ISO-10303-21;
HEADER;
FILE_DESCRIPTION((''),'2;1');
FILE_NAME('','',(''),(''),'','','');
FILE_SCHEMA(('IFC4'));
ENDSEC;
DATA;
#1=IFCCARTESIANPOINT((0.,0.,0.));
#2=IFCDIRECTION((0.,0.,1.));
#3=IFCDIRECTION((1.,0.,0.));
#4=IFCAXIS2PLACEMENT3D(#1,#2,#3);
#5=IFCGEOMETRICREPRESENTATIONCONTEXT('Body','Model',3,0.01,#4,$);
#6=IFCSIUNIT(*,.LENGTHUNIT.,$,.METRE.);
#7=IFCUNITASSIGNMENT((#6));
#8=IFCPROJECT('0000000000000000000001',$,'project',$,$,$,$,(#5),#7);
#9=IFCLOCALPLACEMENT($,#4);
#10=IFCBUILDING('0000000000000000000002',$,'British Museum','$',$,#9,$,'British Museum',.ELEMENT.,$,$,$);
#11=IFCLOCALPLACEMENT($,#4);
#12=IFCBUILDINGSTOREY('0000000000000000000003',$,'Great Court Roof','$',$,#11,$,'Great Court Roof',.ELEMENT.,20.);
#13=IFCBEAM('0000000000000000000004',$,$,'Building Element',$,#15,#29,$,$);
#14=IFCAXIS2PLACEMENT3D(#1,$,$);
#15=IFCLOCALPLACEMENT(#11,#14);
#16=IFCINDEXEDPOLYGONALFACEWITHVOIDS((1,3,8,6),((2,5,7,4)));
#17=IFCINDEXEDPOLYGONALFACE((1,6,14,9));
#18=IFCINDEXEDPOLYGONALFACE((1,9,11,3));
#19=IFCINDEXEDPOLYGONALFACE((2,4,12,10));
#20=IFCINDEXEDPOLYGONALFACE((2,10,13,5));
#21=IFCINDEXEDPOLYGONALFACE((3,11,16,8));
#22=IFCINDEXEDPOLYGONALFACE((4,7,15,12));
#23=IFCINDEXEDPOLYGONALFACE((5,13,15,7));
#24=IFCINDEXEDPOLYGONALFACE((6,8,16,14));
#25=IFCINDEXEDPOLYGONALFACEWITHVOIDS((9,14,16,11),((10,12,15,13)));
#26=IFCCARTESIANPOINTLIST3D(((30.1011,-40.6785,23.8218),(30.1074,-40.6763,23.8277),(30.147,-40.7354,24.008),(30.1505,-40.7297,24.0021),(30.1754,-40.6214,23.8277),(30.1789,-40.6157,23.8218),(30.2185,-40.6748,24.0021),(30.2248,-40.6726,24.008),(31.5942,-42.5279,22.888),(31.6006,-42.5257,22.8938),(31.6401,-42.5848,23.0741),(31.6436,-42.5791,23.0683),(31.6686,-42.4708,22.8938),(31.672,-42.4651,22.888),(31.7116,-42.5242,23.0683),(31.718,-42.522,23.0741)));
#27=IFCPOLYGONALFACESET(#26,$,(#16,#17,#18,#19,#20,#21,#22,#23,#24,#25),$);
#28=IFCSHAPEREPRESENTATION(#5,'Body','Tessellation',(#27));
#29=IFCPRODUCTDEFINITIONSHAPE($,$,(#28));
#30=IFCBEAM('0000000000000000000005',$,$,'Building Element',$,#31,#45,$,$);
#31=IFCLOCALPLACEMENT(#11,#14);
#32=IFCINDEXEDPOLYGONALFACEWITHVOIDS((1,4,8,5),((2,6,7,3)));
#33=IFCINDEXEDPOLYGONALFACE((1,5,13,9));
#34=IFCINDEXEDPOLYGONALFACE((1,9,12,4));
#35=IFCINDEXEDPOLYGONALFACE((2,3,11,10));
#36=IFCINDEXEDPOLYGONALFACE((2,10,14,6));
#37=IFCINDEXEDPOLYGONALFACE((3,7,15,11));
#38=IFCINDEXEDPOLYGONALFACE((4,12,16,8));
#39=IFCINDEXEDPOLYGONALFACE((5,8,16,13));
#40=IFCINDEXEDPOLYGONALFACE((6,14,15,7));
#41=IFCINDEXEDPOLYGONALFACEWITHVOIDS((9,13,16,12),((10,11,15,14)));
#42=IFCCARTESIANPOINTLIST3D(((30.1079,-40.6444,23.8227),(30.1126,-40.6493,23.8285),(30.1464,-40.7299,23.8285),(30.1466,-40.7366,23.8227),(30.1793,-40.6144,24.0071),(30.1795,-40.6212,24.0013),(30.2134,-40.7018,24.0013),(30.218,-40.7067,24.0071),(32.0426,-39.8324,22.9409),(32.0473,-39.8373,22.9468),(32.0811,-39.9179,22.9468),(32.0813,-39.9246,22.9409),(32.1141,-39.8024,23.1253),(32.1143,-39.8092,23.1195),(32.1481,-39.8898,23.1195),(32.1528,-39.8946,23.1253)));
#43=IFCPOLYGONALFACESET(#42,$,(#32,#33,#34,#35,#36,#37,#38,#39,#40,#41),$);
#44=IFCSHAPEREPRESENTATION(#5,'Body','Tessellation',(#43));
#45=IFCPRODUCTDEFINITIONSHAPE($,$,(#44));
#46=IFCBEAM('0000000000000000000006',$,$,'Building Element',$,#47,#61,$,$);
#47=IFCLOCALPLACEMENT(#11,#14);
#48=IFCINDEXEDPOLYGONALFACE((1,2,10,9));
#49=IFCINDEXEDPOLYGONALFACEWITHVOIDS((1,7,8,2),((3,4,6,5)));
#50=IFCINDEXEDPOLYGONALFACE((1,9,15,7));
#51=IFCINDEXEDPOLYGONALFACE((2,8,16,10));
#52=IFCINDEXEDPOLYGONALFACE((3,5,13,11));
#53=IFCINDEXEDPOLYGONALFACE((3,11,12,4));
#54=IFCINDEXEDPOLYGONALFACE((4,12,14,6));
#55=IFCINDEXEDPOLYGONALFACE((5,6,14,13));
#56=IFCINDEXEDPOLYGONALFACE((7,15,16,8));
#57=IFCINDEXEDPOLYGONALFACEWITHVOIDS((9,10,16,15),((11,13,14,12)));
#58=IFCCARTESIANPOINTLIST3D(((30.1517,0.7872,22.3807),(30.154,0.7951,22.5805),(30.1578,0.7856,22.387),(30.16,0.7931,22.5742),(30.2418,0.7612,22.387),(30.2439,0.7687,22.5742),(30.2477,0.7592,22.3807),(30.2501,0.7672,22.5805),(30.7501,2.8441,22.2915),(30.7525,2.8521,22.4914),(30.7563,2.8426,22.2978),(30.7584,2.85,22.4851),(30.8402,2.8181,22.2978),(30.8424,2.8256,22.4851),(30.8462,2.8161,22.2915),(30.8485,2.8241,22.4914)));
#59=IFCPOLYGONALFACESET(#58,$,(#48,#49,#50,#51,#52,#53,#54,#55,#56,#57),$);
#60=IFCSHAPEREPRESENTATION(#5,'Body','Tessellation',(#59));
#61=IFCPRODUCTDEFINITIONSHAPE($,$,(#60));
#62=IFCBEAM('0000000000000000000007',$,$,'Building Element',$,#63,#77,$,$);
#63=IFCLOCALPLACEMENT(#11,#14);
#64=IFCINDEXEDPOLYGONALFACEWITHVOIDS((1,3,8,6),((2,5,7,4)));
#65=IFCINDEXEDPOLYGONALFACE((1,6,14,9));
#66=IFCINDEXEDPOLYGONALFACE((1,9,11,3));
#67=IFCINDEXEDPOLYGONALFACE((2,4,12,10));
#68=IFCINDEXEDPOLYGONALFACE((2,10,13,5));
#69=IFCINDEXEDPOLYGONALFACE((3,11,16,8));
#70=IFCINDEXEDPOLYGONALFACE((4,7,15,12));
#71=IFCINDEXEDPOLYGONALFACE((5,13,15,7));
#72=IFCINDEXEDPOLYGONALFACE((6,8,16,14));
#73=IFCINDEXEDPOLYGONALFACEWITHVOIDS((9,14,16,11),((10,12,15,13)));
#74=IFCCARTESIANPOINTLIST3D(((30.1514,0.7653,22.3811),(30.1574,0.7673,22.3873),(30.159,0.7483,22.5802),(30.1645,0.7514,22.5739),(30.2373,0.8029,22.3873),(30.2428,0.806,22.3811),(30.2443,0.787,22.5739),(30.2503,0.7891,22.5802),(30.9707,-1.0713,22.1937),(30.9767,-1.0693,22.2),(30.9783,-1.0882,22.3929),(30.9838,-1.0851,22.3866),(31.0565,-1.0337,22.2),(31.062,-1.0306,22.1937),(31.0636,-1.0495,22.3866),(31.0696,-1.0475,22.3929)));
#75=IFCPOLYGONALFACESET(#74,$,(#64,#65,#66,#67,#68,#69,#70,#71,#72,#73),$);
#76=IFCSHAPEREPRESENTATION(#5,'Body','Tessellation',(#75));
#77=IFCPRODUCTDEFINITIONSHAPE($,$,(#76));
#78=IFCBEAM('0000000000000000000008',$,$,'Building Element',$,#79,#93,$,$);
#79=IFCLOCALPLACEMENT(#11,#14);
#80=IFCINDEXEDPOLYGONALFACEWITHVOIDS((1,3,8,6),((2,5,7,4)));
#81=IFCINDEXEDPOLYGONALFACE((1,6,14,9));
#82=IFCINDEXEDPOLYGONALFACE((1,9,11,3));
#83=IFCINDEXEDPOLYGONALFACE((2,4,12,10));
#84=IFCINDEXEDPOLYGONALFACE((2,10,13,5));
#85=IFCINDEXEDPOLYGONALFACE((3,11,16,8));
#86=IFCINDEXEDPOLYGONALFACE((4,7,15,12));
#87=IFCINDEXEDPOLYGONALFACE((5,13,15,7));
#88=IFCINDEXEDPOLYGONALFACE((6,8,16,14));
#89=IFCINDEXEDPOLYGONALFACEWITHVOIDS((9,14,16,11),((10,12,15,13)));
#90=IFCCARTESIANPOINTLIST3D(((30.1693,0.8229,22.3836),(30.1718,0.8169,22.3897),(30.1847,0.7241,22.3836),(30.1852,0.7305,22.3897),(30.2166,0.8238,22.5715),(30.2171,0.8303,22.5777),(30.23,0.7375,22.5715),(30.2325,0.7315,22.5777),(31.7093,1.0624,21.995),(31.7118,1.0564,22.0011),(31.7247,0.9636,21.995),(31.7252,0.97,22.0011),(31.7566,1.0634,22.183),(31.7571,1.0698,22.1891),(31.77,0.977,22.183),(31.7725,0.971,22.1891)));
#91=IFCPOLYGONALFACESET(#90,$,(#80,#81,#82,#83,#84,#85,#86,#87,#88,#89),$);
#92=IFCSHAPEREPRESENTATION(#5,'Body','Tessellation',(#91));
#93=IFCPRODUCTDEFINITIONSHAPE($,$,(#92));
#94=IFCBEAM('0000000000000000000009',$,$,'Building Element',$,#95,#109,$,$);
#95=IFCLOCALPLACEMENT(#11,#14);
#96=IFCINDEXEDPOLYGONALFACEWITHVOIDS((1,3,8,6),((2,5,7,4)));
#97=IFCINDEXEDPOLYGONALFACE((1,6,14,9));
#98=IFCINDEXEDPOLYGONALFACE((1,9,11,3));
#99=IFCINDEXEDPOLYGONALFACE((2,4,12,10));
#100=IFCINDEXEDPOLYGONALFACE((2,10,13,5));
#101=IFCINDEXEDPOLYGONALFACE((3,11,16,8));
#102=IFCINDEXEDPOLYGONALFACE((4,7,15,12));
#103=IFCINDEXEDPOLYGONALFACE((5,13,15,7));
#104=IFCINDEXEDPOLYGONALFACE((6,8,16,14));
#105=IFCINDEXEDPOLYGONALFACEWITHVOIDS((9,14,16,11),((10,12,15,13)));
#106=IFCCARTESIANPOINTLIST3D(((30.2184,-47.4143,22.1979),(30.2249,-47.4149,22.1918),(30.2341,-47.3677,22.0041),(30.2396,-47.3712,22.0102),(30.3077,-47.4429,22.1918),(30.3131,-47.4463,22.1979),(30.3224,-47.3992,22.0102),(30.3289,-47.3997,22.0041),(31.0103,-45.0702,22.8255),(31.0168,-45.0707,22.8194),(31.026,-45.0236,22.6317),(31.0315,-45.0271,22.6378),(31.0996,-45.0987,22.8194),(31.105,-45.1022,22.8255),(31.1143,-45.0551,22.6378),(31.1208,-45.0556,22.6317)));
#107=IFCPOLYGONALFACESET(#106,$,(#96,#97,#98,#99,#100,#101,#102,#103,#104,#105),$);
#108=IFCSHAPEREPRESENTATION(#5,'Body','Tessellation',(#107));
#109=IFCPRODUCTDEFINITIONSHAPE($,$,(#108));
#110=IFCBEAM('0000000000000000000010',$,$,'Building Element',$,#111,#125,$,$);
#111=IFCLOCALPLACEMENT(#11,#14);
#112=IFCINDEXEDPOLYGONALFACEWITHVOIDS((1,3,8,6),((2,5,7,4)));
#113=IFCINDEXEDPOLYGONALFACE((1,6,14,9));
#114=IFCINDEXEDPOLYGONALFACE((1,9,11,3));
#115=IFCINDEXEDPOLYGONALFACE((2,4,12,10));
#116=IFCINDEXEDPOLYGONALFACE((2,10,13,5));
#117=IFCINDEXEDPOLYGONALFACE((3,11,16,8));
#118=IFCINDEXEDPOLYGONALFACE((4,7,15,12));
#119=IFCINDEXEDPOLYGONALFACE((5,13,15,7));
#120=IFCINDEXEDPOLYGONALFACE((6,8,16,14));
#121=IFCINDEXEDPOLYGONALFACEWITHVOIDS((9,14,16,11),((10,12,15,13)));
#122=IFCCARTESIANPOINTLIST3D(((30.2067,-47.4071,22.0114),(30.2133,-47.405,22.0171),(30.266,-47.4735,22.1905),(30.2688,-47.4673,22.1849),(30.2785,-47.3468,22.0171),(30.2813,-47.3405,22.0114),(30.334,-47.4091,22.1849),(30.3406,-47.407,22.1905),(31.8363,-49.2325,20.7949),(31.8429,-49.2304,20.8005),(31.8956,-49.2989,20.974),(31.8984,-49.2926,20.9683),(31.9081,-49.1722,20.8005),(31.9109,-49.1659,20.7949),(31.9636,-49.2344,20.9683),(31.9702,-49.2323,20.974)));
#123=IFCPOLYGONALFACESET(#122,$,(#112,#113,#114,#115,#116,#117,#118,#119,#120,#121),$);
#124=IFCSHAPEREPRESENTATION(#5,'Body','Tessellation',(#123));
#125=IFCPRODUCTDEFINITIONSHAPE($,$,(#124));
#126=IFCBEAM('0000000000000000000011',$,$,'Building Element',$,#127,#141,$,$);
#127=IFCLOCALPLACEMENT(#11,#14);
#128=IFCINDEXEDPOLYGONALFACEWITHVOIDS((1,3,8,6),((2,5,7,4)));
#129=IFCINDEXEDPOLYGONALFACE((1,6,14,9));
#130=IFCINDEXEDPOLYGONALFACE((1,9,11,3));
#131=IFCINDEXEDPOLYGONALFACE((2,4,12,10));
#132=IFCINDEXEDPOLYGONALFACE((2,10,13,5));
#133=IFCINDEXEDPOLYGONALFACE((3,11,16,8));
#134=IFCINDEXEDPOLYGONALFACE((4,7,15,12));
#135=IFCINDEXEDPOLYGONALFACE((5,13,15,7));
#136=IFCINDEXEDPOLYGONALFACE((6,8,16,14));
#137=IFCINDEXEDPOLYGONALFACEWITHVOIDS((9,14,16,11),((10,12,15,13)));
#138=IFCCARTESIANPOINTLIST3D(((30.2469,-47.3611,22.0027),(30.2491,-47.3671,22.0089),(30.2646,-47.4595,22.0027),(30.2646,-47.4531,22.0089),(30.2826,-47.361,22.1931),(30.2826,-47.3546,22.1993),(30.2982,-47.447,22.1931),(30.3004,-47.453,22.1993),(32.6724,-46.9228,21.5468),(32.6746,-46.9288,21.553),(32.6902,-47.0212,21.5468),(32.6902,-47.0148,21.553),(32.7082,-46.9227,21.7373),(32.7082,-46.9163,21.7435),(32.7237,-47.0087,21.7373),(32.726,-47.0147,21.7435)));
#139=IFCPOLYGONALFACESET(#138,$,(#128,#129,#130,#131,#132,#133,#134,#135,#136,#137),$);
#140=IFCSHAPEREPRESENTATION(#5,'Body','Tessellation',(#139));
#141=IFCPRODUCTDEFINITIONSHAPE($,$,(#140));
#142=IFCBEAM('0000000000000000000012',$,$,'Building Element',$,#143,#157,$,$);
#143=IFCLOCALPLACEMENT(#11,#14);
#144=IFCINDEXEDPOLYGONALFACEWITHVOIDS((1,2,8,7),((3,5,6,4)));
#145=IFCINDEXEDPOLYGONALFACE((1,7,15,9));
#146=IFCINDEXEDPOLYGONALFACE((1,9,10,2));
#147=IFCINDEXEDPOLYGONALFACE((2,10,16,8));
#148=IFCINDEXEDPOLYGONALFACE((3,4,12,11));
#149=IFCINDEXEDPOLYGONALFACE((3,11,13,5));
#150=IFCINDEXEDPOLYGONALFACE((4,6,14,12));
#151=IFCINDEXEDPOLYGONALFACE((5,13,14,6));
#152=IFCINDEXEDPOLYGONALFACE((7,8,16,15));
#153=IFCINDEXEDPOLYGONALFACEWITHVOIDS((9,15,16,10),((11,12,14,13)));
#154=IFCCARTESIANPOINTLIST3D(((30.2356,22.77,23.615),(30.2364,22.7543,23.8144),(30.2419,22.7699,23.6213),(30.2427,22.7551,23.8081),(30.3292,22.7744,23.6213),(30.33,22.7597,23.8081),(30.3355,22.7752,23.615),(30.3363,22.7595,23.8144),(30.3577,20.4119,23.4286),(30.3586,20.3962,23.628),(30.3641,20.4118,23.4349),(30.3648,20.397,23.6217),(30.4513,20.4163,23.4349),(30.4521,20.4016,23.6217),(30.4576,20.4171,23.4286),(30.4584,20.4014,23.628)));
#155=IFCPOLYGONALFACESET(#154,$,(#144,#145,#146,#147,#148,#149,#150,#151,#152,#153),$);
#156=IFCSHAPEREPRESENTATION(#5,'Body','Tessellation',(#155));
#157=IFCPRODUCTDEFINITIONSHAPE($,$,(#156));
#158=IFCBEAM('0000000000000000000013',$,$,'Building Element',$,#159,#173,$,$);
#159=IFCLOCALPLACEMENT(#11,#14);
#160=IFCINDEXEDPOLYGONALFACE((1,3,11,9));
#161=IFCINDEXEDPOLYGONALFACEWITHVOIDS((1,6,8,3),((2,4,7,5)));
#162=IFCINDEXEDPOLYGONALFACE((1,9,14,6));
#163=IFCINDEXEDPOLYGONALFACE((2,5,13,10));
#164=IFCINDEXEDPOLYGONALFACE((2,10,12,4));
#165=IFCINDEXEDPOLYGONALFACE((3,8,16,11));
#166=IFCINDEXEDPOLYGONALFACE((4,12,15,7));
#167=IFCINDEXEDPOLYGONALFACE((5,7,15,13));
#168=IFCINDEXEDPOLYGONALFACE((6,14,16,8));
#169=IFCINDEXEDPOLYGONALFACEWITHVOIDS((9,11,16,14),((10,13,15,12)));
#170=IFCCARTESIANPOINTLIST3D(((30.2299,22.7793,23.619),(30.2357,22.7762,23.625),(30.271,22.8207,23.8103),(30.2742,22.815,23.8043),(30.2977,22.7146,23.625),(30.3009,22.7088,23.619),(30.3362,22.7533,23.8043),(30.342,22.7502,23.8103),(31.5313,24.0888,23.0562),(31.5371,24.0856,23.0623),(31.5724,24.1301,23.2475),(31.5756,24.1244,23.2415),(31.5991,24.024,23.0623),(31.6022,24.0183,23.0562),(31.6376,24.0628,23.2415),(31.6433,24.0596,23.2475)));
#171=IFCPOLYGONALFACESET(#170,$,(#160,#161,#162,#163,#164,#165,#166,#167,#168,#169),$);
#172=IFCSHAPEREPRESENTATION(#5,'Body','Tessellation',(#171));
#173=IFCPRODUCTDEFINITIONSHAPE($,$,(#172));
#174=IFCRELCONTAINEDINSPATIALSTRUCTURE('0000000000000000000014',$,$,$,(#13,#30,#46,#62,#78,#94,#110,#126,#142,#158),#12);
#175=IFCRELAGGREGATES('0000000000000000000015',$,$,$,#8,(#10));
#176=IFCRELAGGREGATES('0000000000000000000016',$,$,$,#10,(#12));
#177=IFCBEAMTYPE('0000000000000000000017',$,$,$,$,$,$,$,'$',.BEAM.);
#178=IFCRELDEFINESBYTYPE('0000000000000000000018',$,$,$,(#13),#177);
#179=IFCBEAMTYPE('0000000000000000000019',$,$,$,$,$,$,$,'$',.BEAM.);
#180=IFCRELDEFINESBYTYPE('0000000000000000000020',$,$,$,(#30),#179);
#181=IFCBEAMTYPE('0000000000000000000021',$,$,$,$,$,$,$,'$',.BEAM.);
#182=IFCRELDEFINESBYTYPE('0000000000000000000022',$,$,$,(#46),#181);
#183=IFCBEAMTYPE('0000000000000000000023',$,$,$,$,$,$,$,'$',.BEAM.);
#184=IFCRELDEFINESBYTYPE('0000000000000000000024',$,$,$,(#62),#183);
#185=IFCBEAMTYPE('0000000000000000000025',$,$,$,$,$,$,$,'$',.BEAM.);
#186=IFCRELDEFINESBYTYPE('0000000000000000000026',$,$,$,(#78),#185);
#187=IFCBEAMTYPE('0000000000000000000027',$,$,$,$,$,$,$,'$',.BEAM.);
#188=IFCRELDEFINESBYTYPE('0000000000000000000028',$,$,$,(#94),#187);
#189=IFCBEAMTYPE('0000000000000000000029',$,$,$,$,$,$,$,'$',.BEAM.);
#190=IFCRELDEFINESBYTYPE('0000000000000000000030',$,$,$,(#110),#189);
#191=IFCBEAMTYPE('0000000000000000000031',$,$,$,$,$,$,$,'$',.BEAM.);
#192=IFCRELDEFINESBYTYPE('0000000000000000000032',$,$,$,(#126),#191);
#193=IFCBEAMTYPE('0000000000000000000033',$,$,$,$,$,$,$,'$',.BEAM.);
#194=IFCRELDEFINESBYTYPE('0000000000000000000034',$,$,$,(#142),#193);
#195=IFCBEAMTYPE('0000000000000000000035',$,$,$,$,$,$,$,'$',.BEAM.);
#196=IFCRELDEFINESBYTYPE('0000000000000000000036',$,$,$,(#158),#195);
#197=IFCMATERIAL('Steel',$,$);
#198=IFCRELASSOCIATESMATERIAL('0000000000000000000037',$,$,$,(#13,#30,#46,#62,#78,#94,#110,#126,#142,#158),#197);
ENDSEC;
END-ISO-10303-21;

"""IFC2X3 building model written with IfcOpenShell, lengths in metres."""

from ifc_helpers import new_model, si_unit, frame, origin_with_axes, origin_2d, place, context, project, spatial, hollow_rectangle, extrude, material, type_object, element, save


model = new_model("IFC2X3")

# Units and contexts
model_context = context("Model", 3, precision=0.01, world=origin_with_axes(), identifier="Body")
ifc_project = project(units=[si_unit("LENGTHUNIT", "METRE")], contexts=[model_context])

# Building, storey
building_placement = place(None, origin_with_axes())
building = spatial("IfcBuilding", under=ifc_project, at=building_placement, Name="British Museum", Description="$", LongName="British Museum", CompositionType="ELEMENT")
storey_placement = place(None, origin_with_axes())
storey = spatial("IfcBuildingStorey", under=building, at=storey_placement, Name="Great Court Roof", Description="$", LongName="Great Court Roof", CompositionType="ELEMENT", Elevation=20.0)

# Beams
ifc_material = material(Name="Steel")
beam_type_1 = type_object("IfcBeamType", ElementType="$", PredefinedType="BEAM")
beam_1_placement = place(None, origin_with_axes())
element("IfcBeam", 1, at=beam_1_placement, inside=storey, type_object=beam_type_1, material=ifc_material, Description="Building Element", context=model_context, shape_type="SweptSolid", body=[
    extrude(hollow_rectangle(XDim=0.1, YDim=0.2, WallThickness=0.0063, InnerFilletRadius=-0.0063, OuterFilletRadius=0.0, at=origin_2d()), frame((30.163, -40.6755, 23.9149), z_axis=(0.584668, -0.724188, -0.36567), x_axis=(0.778074, 0.628173, 0.0)), (0.0, 0.0, 1.0), 2.5538),
])
beam_type_2 = type_object("IfcBeamType", ElementType="$", PredefinedType="BEAM")
beam_2_placement = place(None, origin_with_axes())
element("IfcBeam", 2, at=beam_2_placement, inside=storey, type_object=beam_type_2, material=ifc_material, Description="Building Element", context=model_context, shape_type="SweptSolid", body=[
    extrude(hollow_rectangle(XDim=0.1, YDim=0.2, WallThickness=0.0063, InnerFilletRadius=-0.0063, OuterFilletRadius=0.0, at=origin_2d()), frame((30.163, -40.6755, 23.9149), z_axis=(0.850068, 0.356782, -0.387416), x_axis=(-0.387005, 0.922078, 0.0)), (0.0, 0.0, 1.0), 2.276),
])
beam_type_3 = type_object("IfcBeamType", ElementType="$", PredefinedType="BEAM")
beam_3_placement = place(None, origin_with_axes())
element("IfcBeam", 3, at=beam_3_placement, inside=storey, type_object=beam_type_3, material=ifc_material, Description="Building Element", context=model_context, shape_type="SweptSolid", body=[
    extrude(hollow_rectangle(XDim=0.1, YDim=0.2, WallThickness=0.0063, InnerFilletRadius=-0.0063, OuterFilletRadius=0.0, at=origin_2d()), frame((30.2009, 0.7772, 22.4806), z_axis=(0.279107, 0.959359, -0.04159), x_axis=(-0.96019, 0.279349, 0.0)), (0.0, 0.0, 1.0), 2.144),
])
beam_type_4 = type_object("IfcBeamType", ElementType="$", PredefinedType="BEAM")
beam_4_placement = place(None, origin_with_axes())
element("IfcBeam", 4, at=beam_4_placement, inside=storey, type_object=beam_type_4, material=ifc_material, Description="Building Element", context=model_context, shape_type="SweptSolid", body=[
    extrude(hollow_rectangle(XDim=0.1, YDim=0.2, WallThickness=0.0063, InnerFilletRadius=-0.0063, OuterFilletRadius=0.0, at=origin_2d()), frame((30.2009, 0.7772, 22.4806), z_axis=(0.405629, -0.90932, -0.092745), x_axis=(0.913257, 0.407385, 0.0)), (0.0, 0.0, 1.0), 2.0197),
])
beam_type_5 = type_object("IfcBeamType", ElementType="$", PredefinedType="BEAM")
beam_5_placement = place(None, origin_with_axes())
element("IfcBeam", 5, at=beam_5_placement, inside=storey, type_object=beam_type_5, material=ifc_material, Description="Building Element", context=model_context, shape_type="SweptSolid", body=[
    extrude(hollow_rectangle(XDim=0.1, YDim=0.2, WallThickness=0.0063, InnerFilletRadius=-0.0063, OuterFilletRadius=0.0, at=origin_2d()), frame((30.2009, 0.7772, 22.4806), z_axis=(0.958771, 0.149124, -0.241908), x_axis=(-0.153689, 0.988119, 0.0)), (0.0, 0.0, 1.0), 1.6063),
])
beam_type_6 = type_object("IfcBeamType", ElementType="$", PredefinedType="BEAM")
beam_6_placement = place(None, origin_with_axes())
element("IfcBeam", 6, at=beam_6_placement, inside=storey, type_object=beam_type_6, material=ifc_material, Description="Building Element", context=model_context, shape_type="SweptSolid", body=[
    extrude(hollow_rectangle(XDim=0.1, YDim=0.2, WallThickness=0.0063, InnerFilletRadius=-0.0063, OuterFilletRadius=0.0, at=origin_2d()), frame((30.2736, -47.407, 22.101), z_axis=(0.310226, 0.918317, 0.245873), x_axis=(-0.9474, 0.320051, 0.0)), (0.0, 0.0, 1.0), 2.5526),
])
beam_type_7 = type_object("IfcBeamType", ElementType="$", PredefinedType="BEAM")
beam_7_placement = place(None, origin_with_axes())
element("IfcBeam", 7, at=beam_7_placement, inside=storey, type_object=beam_type_7, material=ifc_material, Description="Building Element", context=model_context, shape_type="SweptSolid", body=[
    extrude(hollow_rectangle(XDim=0.1, YDim=0.2, WallThickness=0.0063, InnerFilletRadius=-0.0063, OuterFilletRadius=0.0, at=origin_2d()), frame((30.2736, -47.407, 22.101), z_axis=(0.596341, -0.667973, -0.445185), x_axis=(0.745972, 0.665977, 0.0)), (0.0, 0.0, 1.0), 2.7327),
])
beam_type_8 = type_object("IfcBeamType", ElementType="$", PredefinedType="BEAM")
beam_8_placement = place(None, origin_with_axes())
element("IfcBeam", 8, at=beam_8_placement, inside=storey, type_object=beam_type_8, material=ifc_material, Description="Building Element", context=model_context, shape_type="SweptSolid", body=[
    extrude(hollow_rectangle(XDim=0.1, YDim=0.2, WallThickness=0.0063, InnerFilletRadius=-0.0063, OuterFilletRadius=0.0, at=origin_2d()), frame((30.2736, -47.407, 22.101), z_axis=(0.967653, 0.174859, -0.181859), x_axis=(-0.177824, 0.984062, 0.0)), (0.0, 0.0, 1.0), 2.5066),
])
beam_type_9 = type_object("IfcBeamType", ElementType="$", PredefinedType="BEAM")
beam_9_placement = place(None, origin_with_axes())
element("IfcBeam", 9, at=beam_9_placement, inside=storey, type_object=beam_type_9, material=ifc_material, Description="Building Element", context=model_context, shape_type="SweptSolid", body=[
    extrude(hollow_rectangle(XDim=0.1, YDim=0.2, WallThickness=0.0063, InnerFilletRadius=-0.0063, OuterFilletRadius=0.0, at=origin_2d()), frame((30.2859, 22.7648, 23.7147), z_axis=(0.051568, -0.995566, -0.078677), x_axis=(0.998661, 0.051728, 0.0)), (0.0, 0.0, 1.0), 2.3686),
])
beam_type_10 = type_object("IfcBeamType", ElementType="$", PredefinedType="BEAM")
beam_10_placement = place(None, origin_with_axes())
element("IfcBeam", 10, at=beam_10_placement, inside=storey, type_object=beam_type_10, material=ifc_material, Description="Building Element", context=model_context, shape_type="SweptSolid", body=[
    extrude(hollow_rectangle(XDim=0.1, YDim=0.2, WallThickness=0.0063, InnerFilletRadius=-0.0063, OuterFilletRadius=0.0, at=origin_2d()), frame((30.2859, 22.7648, 23.7147), z_axis=(0.674283, 0.678465, -0.291596), x_axis=(-0.709289, 0.704917, 0.0)), (0.0, 0.0, 1.0), 1.93),
])

save(model, "model.ifc")
